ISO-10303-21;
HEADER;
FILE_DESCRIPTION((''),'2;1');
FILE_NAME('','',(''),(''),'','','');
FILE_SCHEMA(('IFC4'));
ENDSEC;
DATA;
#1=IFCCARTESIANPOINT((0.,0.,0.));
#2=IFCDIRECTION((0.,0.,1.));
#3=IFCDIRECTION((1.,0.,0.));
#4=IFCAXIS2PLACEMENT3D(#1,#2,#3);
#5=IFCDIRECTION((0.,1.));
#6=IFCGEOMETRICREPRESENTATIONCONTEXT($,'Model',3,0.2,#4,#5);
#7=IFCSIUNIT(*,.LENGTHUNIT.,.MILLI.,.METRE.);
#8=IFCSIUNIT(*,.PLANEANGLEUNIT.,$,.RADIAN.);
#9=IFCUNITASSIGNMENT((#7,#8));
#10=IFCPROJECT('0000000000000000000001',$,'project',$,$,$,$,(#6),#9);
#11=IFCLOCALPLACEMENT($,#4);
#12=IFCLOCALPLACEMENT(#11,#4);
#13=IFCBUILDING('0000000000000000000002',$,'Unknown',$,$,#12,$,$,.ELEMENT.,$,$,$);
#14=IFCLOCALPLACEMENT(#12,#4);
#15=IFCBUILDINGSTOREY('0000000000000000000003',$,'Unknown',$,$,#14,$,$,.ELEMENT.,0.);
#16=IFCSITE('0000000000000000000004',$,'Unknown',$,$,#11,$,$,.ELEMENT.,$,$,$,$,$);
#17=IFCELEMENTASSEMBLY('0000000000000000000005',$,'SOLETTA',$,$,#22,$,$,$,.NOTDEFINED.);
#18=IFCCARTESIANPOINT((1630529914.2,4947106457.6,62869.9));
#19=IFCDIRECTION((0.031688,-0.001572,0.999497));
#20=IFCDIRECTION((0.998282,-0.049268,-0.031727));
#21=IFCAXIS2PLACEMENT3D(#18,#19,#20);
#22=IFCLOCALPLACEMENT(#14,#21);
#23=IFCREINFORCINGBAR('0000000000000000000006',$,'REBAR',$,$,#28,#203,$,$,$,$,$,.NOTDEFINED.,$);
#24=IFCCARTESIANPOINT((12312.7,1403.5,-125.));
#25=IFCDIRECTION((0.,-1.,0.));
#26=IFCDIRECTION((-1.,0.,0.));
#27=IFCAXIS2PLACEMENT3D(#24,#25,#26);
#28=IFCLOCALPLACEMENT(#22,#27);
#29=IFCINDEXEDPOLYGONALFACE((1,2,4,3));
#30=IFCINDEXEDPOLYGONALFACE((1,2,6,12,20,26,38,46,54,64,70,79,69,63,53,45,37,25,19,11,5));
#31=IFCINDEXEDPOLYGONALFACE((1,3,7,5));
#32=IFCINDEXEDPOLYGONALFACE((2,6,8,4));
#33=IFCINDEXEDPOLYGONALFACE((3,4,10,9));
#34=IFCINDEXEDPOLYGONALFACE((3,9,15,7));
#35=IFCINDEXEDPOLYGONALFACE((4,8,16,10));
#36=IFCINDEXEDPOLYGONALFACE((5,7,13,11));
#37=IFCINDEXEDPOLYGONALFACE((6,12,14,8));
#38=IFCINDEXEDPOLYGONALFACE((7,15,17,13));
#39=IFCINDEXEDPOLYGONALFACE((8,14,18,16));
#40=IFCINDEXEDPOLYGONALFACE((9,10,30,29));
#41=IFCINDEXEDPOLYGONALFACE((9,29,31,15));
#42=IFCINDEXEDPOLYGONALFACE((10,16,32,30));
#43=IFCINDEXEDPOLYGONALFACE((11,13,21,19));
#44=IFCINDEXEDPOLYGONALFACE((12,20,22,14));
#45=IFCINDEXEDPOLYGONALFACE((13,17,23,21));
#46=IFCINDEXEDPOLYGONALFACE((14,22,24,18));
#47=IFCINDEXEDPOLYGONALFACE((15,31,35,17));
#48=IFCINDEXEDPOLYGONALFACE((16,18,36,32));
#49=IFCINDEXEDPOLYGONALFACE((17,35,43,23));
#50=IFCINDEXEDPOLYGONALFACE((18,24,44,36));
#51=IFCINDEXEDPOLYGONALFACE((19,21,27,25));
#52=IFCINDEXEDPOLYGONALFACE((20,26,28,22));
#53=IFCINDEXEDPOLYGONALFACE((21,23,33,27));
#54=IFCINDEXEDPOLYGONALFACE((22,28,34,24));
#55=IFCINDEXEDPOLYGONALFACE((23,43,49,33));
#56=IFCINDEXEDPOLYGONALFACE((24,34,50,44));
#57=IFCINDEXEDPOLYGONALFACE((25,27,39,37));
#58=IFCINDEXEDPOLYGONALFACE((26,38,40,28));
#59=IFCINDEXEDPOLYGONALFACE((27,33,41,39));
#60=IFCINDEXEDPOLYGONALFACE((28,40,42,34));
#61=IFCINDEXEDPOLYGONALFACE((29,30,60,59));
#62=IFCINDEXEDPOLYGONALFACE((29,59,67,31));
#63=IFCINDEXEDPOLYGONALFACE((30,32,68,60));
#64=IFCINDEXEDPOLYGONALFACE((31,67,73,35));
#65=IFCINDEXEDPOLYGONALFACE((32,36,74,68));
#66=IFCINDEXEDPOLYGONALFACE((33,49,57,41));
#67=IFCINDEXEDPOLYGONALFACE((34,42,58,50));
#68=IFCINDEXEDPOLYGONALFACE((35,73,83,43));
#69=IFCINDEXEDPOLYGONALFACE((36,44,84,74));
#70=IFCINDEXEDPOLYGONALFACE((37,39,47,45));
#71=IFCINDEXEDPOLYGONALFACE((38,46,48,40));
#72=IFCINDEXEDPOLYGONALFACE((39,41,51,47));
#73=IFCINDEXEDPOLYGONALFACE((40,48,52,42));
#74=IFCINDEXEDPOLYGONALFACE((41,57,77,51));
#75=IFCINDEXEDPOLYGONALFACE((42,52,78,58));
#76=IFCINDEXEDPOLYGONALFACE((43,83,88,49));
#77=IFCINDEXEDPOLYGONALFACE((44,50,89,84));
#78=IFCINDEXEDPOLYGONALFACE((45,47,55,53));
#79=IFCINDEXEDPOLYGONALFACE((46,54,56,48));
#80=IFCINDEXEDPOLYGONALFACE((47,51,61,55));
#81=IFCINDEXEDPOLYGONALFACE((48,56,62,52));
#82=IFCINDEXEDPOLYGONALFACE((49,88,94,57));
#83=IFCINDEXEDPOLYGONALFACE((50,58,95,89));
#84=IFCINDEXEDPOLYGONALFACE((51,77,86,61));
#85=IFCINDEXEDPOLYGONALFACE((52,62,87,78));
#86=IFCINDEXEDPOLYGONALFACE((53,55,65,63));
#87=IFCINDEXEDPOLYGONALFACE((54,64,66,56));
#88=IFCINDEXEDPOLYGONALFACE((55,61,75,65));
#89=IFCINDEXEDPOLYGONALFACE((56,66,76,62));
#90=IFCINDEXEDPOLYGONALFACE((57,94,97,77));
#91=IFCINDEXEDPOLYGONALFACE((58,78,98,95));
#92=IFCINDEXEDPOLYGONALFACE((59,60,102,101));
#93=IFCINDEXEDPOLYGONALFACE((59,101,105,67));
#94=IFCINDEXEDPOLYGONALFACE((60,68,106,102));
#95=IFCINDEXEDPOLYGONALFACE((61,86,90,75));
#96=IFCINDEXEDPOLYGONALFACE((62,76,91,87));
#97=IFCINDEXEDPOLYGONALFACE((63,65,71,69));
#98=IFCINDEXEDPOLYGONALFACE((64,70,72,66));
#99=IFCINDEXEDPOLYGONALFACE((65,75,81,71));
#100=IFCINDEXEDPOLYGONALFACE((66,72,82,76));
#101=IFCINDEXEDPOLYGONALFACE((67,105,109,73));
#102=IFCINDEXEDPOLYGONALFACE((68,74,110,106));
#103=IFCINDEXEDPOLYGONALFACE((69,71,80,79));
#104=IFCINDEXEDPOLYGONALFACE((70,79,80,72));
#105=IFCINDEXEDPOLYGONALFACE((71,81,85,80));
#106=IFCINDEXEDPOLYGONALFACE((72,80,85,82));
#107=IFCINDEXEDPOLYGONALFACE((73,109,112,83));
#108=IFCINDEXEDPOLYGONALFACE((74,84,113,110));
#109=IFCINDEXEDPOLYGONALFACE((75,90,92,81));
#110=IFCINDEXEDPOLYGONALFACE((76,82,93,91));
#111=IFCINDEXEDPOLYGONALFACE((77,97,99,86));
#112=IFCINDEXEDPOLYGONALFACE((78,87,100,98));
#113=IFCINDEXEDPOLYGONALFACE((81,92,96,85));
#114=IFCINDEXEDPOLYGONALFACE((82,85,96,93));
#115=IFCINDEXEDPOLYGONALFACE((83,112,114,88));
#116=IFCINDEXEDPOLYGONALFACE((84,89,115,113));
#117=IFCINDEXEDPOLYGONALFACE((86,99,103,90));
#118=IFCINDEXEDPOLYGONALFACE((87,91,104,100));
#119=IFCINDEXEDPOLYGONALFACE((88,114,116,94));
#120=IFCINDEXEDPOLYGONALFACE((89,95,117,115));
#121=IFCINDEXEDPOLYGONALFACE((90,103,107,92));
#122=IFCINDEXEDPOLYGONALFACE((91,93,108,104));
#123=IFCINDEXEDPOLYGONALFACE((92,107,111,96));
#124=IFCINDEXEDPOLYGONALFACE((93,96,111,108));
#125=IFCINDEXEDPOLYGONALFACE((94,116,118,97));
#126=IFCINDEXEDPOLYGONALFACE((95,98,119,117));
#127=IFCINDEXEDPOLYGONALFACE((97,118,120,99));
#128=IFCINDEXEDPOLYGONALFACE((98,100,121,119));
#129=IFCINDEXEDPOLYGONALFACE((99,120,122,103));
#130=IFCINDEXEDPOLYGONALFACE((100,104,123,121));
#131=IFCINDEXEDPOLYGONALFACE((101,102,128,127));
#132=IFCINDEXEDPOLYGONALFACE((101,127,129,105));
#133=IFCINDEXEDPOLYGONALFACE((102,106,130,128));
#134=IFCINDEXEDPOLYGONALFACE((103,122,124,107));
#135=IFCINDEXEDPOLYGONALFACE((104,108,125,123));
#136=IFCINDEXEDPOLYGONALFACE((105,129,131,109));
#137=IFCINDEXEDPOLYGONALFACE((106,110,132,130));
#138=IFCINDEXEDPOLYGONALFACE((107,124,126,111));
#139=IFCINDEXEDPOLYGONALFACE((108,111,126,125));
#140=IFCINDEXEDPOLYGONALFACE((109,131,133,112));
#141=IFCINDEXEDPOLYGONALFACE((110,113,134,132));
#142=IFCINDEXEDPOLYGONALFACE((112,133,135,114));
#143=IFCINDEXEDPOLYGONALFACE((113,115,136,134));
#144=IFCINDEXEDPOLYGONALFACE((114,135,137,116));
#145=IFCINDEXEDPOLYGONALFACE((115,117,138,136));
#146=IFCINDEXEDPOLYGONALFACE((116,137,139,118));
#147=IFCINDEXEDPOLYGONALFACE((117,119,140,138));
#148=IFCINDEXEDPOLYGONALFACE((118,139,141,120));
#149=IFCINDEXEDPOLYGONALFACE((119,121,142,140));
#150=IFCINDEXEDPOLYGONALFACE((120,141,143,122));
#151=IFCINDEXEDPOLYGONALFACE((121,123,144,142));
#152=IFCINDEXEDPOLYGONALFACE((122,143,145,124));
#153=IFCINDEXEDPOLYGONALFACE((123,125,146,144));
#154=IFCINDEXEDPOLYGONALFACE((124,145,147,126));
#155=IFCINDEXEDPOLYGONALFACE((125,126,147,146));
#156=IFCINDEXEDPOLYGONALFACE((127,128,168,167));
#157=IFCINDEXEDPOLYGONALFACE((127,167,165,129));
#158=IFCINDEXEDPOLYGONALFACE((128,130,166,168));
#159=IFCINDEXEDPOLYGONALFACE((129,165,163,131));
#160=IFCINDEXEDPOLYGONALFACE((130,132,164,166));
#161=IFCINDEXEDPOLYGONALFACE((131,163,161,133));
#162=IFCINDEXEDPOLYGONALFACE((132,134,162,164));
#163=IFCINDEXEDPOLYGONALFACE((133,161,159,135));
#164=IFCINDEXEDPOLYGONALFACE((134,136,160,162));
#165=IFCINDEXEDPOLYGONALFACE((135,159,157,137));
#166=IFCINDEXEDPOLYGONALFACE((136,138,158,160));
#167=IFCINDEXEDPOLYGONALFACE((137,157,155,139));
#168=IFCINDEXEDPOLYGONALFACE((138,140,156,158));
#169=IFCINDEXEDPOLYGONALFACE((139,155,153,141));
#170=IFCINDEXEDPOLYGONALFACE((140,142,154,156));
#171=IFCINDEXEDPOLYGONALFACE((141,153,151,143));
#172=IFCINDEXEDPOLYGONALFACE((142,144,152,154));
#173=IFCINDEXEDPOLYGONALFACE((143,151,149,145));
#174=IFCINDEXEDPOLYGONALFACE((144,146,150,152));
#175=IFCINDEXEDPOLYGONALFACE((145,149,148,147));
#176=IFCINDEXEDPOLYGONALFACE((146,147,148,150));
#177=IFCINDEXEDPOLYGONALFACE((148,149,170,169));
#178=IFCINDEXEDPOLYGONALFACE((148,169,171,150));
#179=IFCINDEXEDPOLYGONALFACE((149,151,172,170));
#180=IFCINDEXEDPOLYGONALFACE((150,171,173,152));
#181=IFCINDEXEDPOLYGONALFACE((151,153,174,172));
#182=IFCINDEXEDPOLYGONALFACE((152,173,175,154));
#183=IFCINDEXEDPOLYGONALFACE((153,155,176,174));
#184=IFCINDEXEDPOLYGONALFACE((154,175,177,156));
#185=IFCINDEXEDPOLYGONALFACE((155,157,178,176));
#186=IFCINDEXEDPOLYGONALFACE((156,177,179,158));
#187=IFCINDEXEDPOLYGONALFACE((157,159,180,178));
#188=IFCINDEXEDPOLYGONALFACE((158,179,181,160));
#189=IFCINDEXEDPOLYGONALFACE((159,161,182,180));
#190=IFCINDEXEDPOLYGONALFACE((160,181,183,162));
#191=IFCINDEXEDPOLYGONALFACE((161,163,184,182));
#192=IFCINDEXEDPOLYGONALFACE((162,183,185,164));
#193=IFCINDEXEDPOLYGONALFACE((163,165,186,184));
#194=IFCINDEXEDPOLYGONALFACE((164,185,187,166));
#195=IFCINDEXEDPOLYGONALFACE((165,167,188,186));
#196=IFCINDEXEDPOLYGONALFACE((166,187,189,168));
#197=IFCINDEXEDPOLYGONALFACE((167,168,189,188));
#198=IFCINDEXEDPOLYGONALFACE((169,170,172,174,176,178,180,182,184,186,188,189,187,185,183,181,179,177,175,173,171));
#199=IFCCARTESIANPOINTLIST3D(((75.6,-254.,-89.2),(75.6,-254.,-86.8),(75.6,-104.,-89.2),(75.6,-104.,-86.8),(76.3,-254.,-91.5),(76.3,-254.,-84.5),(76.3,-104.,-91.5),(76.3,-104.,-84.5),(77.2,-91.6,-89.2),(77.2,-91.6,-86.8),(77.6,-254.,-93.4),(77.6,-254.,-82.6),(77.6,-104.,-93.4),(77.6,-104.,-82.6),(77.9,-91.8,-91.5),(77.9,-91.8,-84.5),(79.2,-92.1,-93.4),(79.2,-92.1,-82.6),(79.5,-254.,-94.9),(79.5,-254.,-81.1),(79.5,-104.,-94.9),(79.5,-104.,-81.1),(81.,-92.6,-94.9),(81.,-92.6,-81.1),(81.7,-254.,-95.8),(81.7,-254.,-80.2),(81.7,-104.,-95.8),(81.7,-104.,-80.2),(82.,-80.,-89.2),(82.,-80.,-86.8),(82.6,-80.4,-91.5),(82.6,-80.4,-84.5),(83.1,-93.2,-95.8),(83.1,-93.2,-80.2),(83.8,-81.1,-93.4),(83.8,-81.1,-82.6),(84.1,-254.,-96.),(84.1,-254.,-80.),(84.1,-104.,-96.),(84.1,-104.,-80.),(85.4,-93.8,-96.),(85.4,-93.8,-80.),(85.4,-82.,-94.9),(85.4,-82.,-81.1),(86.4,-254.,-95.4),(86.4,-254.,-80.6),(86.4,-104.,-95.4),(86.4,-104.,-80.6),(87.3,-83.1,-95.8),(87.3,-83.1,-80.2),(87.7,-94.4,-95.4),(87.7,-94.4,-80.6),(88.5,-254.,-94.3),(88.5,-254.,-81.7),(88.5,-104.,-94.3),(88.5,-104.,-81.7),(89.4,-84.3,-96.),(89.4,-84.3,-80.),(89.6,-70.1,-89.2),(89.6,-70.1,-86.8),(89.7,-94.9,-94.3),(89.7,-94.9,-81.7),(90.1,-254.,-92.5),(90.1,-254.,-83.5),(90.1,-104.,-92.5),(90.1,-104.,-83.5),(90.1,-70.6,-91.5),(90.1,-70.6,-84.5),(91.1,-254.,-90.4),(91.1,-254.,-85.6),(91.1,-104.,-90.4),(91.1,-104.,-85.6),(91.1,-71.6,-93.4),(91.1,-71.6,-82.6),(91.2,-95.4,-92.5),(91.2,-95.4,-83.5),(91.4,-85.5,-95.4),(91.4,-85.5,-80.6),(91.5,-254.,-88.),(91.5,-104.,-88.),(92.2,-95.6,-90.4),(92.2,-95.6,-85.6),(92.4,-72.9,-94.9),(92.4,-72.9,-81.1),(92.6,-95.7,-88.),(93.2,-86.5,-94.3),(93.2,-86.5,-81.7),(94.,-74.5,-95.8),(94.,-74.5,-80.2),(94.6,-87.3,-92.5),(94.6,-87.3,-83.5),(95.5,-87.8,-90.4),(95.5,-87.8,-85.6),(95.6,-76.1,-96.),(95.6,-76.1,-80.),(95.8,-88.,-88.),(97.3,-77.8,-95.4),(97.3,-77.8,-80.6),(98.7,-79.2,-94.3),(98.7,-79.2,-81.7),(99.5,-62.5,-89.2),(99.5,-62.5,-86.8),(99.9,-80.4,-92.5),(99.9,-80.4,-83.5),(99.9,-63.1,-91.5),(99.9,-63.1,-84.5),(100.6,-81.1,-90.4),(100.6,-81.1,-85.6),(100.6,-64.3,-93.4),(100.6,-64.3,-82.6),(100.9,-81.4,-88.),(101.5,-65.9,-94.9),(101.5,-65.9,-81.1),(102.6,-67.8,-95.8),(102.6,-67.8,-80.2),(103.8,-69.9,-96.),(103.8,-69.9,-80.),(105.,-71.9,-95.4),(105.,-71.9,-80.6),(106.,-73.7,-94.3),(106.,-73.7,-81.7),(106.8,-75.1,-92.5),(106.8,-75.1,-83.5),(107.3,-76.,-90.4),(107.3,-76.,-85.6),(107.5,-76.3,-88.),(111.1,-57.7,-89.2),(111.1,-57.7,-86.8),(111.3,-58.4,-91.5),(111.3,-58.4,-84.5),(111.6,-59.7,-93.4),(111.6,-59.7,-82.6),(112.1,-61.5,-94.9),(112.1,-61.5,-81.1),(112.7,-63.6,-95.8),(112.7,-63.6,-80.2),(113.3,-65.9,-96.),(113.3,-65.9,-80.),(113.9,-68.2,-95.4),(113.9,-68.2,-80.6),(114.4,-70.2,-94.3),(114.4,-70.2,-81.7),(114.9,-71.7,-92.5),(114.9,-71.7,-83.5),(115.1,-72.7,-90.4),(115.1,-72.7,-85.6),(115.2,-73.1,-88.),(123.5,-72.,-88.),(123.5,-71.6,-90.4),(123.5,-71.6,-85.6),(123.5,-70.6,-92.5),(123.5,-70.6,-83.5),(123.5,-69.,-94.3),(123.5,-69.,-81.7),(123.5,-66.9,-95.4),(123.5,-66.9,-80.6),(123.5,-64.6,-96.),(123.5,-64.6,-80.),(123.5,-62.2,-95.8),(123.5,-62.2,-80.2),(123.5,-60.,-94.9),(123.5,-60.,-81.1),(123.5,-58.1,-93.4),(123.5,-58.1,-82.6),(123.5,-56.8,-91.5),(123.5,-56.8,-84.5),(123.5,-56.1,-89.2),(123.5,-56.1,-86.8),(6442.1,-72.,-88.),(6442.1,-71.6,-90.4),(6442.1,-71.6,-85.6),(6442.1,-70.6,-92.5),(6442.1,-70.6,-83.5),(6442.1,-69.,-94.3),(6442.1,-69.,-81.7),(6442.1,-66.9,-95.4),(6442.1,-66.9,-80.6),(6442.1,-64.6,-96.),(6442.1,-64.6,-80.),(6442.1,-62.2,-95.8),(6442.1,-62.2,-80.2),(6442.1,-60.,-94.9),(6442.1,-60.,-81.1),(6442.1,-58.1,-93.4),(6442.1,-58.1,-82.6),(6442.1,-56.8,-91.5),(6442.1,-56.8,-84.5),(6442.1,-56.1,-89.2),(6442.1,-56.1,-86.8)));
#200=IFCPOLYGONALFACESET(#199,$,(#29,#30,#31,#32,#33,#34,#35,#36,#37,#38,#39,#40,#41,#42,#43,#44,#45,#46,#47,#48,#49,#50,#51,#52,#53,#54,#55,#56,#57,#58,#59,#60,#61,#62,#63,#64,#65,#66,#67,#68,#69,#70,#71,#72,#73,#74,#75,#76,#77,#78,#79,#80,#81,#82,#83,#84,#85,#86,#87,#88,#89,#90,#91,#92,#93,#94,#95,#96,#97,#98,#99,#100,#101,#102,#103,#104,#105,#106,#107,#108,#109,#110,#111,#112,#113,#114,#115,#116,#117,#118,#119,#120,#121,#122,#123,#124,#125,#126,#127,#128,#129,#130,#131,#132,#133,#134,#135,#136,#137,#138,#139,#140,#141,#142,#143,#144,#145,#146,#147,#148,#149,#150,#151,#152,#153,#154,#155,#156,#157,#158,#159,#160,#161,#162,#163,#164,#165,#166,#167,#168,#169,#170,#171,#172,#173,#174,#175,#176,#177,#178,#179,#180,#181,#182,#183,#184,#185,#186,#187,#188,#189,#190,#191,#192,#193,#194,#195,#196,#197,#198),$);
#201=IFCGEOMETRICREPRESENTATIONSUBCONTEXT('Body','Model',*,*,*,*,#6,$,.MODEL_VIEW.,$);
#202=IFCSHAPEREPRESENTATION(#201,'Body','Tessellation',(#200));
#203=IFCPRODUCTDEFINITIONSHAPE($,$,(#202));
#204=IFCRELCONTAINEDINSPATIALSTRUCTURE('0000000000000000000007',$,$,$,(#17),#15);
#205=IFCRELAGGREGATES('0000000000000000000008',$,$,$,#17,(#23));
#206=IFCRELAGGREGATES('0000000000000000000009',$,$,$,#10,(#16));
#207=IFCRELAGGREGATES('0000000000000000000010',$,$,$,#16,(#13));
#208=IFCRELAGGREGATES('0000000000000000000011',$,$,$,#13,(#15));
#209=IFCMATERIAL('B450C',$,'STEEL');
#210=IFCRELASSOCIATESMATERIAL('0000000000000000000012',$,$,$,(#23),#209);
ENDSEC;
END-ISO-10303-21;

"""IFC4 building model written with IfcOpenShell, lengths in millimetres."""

from ifc_helpers import new_model, entity, si_unit, direction, frame, origin_with_axes, place, context, subcontext, project, spatial, material, element, aggregate, save


model = new_model("IFC4")

# Units and contexts
model_context = context("Model", 3, precision=0.2, world=origin_with_axes(), true_north=direction((0.0, 1.0)))
body_context = subcontext(model_context, "Body", "Model", "MODEL_VIEW")
ifc_project = project(units=[si_unit("LENGTHUNIT", "METRE", prefix="MILLI"), si_unit("PLANEANGLEUNIT", "RADIAN")], contexts=[model_context])

# Site, building, storey
site_placement = place(None, origin_with_axes())
site = spatial("IfcSite", under=ifc_project, at=site_placement, Name="Unknown", CompositionType="ELEMENT")
building_placement = place(site_placement, origin_with_axes())
building = spatial("IfcBuilding", under=site, at=building_placement, Name="Unknown", CompositionType="ELEMENT")
storey_placement = place(building_placement, origin_with_axes())
storey = spatial("IfcBuildingStorey", under=building, at=storey_placement, Name="Unknown", CompositionType="ELEMENT", Elevation=0.0)

# Shared definitions
ifc_material = material(Name="B450C", Category="STEEL")

# Element assembly, reinforcing bar
assembly_1_placement = place(storey_placement, frame((1630529914.2, 4947106457.6, 62869.9), z_axis=(0.031688, -0.001572, 0.999497), x_axis=(0.998282, -0.049268, -0.031727)))
assembly_1 = element("IfcElementAssembly", 1, at=assembly_1_placement, inside=storey, Name="SOLETTA", PredefinedType="NOTDEFINED")
reinforcing_bar_1_placement = place(assembly_1_placement, frame((12312.7, 1403.5, -125.0), z_axis=(0.0, -1.0, 0.0), x_axis=(-1.0, 0.0, 0.0)))
reinforcing_bar_1 = element("IfcReinforcingBar", 2, at=reinforcing_bar_1_placement, material=ifc_material, Name="REBAR", PredefinedType="NOTDEFINED", context=body_context, shape_type="AdvancedSweptSolid", body=[
    entity("IfcSweptDiskSolid", entity("IfcIndexedPolyCurve", entity("IfcCartesianPointList3D", [[83.5, -254.0, -88.0], [83.5, -104.0, -88.0], [95.2, -75.7, -88.0], [123.5, -64.0, -88.0], [6442.1, -64.0, -88.0]]), [entity("IfcLineIndex", [1, 2]), entity("IfcArcIndex", [2, 3, 4]), entity("IfcLineIndex", [4, 5])]), 8.0),
])
aggregate(assembly_1, [reinforcing_bar_1])

save(model, "model.ifc")
